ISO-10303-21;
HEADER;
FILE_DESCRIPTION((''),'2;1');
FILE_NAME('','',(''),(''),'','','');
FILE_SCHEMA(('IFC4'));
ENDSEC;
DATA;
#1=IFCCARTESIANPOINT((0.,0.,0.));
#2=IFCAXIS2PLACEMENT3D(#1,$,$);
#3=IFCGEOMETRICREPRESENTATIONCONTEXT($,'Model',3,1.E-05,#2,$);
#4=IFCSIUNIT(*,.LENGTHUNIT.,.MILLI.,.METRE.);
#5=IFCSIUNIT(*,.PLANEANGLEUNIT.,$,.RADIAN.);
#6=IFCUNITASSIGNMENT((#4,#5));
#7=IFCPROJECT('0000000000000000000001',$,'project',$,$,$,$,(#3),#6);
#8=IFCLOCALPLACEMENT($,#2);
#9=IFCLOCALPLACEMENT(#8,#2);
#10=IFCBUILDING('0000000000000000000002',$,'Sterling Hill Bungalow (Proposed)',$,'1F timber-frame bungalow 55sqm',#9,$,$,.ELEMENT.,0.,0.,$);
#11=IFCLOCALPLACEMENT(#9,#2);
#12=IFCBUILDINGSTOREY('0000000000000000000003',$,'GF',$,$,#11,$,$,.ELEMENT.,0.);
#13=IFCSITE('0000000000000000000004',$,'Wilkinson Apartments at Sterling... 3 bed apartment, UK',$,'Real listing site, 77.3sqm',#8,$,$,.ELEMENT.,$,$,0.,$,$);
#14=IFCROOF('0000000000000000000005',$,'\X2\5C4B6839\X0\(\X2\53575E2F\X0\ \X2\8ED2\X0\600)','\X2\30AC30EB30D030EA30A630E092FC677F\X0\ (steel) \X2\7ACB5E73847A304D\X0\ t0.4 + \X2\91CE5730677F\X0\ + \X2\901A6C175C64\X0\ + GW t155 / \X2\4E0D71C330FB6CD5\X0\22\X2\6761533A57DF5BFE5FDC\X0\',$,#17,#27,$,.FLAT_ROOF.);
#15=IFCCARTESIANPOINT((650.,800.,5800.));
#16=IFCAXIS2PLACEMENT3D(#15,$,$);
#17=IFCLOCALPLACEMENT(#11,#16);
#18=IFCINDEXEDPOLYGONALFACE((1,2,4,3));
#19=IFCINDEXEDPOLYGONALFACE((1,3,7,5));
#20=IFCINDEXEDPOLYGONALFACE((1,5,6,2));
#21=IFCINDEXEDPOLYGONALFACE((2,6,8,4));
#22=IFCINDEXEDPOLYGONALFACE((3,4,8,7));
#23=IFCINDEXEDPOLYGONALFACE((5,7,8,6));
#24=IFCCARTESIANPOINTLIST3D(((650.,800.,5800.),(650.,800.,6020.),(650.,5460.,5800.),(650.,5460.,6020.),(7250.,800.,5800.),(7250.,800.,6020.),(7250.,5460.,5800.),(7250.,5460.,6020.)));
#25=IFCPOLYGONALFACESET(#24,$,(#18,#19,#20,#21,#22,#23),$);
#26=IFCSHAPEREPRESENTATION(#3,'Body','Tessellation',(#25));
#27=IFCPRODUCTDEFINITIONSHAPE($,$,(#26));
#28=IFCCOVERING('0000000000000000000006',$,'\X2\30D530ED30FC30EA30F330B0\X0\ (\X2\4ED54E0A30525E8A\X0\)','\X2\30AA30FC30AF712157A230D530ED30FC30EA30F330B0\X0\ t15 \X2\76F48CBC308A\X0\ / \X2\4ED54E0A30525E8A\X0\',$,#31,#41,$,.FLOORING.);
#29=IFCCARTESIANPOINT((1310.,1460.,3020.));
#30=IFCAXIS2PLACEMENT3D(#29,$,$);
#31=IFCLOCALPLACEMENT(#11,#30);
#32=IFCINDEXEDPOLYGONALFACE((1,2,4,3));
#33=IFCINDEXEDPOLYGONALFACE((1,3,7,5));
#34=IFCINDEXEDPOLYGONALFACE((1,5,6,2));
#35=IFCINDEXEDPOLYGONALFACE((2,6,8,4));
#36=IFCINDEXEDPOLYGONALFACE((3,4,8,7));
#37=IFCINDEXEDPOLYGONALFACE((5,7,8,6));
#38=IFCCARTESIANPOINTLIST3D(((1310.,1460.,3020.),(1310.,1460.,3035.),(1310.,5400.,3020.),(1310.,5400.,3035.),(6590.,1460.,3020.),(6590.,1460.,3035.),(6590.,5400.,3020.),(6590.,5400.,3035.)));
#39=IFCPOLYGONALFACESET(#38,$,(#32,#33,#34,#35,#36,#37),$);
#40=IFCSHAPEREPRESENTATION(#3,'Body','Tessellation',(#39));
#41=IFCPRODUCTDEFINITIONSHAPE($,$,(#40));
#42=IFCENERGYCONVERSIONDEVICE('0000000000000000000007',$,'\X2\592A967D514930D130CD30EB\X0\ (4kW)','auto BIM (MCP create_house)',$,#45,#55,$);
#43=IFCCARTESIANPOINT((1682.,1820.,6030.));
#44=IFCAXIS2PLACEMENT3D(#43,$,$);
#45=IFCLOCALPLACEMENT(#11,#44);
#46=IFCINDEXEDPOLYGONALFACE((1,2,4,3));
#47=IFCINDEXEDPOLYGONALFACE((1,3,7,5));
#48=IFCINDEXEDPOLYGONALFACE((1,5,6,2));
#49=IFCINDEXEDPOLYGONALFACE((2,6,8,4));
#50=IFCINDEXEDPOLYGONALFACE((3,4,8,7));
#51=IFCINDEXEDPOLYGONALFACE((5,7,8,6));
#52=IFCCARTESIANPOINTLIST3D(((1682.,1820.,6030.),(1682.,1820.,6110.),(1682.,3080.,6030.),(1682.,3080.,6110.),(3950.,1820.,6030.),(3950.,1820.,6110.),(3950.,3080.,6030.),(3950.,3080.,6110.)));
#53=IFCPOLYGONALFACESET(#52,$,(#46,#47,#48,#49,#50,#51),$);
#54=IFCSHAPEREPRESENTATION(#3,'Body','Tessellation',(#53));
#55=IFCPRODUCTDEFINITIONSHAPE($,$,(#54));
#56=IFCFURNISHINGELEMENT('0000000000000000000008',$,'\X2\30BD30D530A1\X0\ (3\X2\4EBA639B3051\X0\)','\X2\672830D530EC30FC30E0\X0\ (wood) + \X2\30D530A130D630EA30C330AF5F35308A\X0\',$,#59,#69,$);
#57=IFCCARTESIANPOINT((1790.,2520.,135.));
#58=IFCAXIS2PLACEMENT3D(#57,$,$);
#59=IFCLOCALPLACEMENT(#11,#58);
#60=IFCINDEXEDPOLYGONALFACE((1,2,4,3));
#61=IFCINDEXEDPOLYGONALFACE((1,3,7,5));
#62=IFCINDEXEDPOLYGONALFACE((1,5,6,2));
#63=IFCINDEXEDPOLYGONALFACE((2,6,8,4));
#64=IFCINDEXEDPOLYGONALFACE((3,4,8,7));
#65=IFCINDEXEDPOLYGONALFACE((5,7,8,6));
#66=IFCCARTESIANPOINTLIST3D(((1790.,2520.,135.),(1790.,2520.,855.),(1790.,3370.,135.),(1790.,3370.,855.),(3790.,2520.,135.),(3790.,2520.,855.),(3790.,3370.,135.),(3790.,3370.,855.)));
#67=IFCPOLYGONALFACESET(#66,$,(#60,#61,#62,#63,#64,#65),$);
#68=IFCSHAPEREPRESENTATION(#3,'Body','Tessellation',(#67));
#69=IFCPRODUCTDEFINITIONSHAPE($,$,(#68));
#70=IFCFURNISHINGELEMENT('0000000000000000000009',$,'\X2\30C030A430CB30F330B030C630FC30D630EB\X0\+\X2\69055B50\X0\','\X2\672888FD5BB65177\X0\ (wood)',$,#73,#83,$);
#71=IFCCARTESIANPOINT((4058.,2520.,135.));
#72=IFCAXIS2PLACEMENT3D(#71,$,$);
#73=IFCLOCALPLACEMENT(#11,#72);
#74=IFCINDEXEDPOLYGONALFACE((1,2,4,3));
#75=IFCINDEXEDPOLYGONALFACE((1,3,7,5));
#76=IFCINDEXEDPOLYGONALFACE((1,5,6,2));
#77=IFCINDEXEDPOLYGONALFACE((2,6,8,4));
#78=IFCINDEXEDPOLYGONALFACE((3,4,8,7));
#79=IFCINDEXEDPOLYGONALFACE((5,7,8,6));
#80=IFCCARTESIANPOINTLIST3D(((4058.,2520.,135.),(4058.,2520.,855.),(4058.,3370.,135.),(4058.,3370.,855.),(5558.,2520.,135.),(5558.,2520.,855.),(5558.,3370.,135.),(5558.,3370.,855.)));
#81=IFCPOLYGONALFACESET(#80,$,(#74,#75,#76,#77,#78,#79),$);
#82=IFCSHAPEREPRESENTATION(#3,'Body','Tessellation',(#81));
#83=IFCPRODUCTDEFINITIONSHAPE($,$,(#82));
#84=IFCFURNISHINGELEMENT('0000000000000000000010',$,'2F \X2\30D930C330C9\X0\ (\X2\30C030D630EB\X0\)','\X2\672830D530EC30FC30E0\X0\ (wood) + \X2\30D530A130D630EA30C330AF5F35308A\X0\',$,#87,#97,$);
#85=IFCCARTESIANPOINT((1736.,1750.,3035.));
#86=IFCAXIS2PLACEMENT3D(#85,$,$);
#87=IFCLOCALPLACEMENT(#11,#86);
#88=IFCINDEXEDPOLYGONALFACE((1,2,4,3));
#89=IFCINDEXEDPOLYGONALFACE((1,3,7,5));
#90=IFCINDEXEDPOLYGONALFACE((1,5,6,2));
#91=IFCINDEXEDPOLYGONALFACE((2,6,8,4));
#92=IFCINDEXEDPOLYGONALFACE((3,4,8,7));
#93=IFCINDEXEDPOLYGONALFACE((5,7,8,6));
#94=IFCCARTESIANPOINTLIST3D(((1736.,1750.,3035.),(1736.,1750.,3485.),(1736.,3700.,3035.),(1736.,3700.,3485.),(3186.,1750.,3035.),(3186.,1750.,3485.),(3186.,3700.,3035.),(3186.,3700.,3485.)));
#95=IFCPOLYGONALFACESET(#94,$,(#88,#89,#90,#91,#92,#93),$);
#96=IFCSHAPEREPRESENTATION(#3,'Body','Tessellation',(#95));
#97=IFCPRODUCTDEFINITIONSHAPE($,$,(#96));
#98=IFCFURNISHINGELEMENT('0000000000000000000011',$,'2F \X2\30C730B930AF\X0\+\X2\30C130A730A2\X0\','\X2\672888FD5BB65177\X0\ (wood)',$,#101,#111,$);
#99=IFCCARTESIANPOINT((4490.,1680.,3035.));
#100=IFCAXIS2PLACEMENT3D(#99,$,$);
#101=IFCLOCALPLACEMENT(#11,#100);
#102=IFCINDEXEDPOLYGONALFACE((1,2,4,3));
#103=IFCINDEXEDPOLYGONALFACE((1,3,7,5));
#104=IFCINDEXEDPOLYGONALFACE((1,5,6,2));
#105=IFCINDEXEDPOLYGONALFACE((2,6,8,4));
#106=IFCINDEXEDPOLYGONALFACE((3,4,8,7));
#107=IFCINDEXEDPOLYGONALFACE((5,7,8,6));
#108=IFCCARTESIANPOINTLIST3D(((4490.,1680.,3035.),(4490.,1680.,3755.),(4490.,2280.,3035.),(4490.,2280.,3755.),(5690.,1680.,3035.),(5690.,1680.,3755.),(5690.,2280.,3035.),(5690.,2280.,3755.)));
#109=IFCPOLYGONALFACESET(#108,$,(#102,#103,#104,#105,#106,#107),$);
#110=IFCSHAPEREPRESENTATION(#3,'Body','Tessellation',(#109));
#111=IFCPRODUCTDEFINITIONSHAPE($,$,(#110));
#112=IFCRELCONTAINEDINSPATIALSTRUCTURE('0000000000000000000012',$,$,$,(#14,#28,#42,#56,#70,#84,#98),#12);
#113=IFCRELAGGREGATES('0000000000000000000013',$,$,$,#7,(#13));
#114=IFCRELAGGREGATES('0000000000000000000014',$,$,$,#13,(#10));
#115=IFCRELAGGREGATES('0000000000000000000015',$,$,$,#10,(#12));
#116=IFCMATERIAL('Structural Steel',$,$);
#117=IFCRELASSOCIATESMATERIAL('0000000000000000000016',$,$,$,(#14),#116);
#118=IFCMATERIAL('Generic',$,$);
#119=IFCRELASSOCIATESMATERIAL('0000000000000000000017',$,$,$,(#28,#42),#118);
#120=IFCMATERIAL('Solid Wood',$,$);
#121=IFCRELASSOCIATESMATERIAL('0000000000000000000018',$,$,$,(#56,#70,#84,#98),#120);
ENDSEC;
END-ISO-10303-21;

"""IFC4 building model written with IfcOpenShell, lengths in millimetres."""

from ifc_helpers import new_model, si_unit, frame, frame_2d, origin, place, context, project, spatial, rectangle, extrude, material, element, save


model = new_model("IFC4")

# Units and contexts
model_context = context("Model", 3, precision=1e-05, world=origin())
ifc_project = project(units=[si_unit("LENGTHUNIT", "METRE", prefix="MILLI"), si_unit("PLANEANGLEUNIT", "RADIAN")], contexts=[model_context])

# Site, building, storey
site_placement = place(None, origin())
site = spatial("IfcSite", under=ifc_project, at=site_placement, Name="Wilkinson Apartments at Sterling... 3 bed apartment, UK", ObjectType="Real listing site, 77.3sqm", CompositionType="ELEMENT", RefElevation=0.0)
building_placement = place(site_placement, origin())
building = spatial("IfcBuilding", under=site, at=building_placement, Name="Sterling Hill Bungalow (Proposed)", ObjectType="1F timber-frame bungalow 55sqm", CompositionType="ELEMENT", ElevationOfRefHeight=0.0, ElevationOfTerrain=0.0)
storey_placement = place(building_placement, origin())
storey = spatial("IfcBuildingStorey", under=building, at=storey_placement, Name="GF", CompositionType="ELEMENT", Elevation=0.0)

# Shared definitions
ifc_material_1 = material(Name="Solid Wood")

# Shared definitions
ifc_material_2 = material(Name="Generic")

# Roof
ifc_material_3 = material(Name="Structural Steel")
for number, where, name in (
    (1, (650.0, 800.0, 5800.0), "屋根(南帯 軒600)"),
):
    element("IfcRoof", number, at=place(storey_placement, frame(where)), inside=storey, material=ifc_material_3, Name=name, Description="ガルバリウム鋼板 (steel) 立平葺き t0.4 + 野地板 + 通気層 + GW t155 / 不燃・法22条区域対応", PredefinedType="FLAT_ROOF", context=model_context, shape_type="SweptSolid", body=[
        extrude(rectangle(XDim=6600.0, YDim=4660.0, at=frame_2d((3300.0, 2330.0))), frame((650.0, 800.0, 5800.0)), (0.0, 0.0, 1.0), 220.0),
    ])

# Covering
covering_placement = place(storey_placement, frame((1310.0, 1460.0, 3020.0)))
element("IfcCovering", 2, at=covering_placement, inside=storey, material=ifc_material_2, Name="フローリング (仕上げ床)", Description="オーク無垢フローリング t15 直貼り / 仕上げ床", PredefinedType="FLOORING", context=model_context, shape_type="SweptSolid", body=[
    extrude(rectangle(XDim=5280.0, YDim=3940.0, at=frame_2d((2640.0, 1970.0))), frame((1310.0, 1460.0, 3020.0)), (0.0, 0.0, 1.0), 15.0),
])

# Energy conversion device
energy_conversion_device_placement = place(storey_placement, frame((1682.0, 1820.0, 6030.0)))
element("IfcEnergyConversionDevice", 3, at=energy_conversion_device_placement, inside=storey, material=ifc_material_2, Name="太陽光パネル (4kW)", Description="auto BIM (MCP create_house)", context=model_context, shape_type="SweptSolid", body=[
    extrude(rectangle(XDim=2268.0, YDim=1260.0, at=frame_2d((1134.0, 630.0))), frame((1682.0, 1820.0, 6030.0)), (0.0, 0.0, 1.0), 80.0),
])

# Furnishing elements
furnishing_1_placement = place(storey_placement, frame((1790.0, 2520.0, 135.0)))
element("IfcFurnishingElement", 4, at=furnishing_1_placement, inside=storey, material=ifc_material_1, Name="ソファ (3人掛け)", Description="木フレーム (wood) + ファブリック張り", context=model_context, shape_type="SweptSolid", body=[
    extrude(rectangle(XDim=2000.0, YDim=850.0, at=frame_2d((1000.0, 425.0))), frame((1790.0, 2520.0, 135.0)), (0.0, 0.0, 1.0), 720.0),
])
furnishing_2_placement = place(storey_placement, frame((4058.0, 2520.0, 135.0)))
element("IfcFurnishingElement", 5, at=furnishing_2_placement, inside=storey, material=ifc_material_1, Name="ダイニングテーブル+椅子", Description="木製家具 (wood)", context=model_context, shape_type="SweptSolid", body=[
    extrude(rectangle(XDim=1500.0, YDim=850.0, at=frame_2d((750.0, 425.0))), frame((4058.0, 2520.0, 135.0)), (0.0, 0.0, 1.0), 720.0),
])
furnishing_3_placement = place(storey_placement, frame((1736.0, 1750.0, 3035.0)))
element("IfcFurnishingElement", 6, at=furnishing_3_placement, inside=storey, material=ifc_material_1, Name="2F ベッド (ダブル)", Description="木フレーム (wood) + ファブリック張り", context=model_context, shape_type="SweptSolid", body=[
    extrude(rectangle(XDim=1450.0, YDim=1950.0, at=frame_2d((725.0, 975.0))), frame((1736.0, 1750.0, 3035.0)), (0.0, 0.0, 1.0), 450.0),
])
furnishing_4_placement = place(storey_placement, frame((4490.0, 1680.0, 3035.0)))
element("IfcFurnishingElement", 7, at=furnishing_4_placement, inside=storey, material=ifc_material_1, Name="2F デスク+チェア", Description="木製家具 (wood)", context=model_context, shape_type="SweptSolid", body=[
    extrude(rectangle(XDim=1200.0, YDim=600.0, at=frame_2d((600.0, 300.0))), frame((4490.0, 1680.0, 3035.0)), (0.0, 0.0, 1.0), 720.0),
])

save(model, "model.ifc")
